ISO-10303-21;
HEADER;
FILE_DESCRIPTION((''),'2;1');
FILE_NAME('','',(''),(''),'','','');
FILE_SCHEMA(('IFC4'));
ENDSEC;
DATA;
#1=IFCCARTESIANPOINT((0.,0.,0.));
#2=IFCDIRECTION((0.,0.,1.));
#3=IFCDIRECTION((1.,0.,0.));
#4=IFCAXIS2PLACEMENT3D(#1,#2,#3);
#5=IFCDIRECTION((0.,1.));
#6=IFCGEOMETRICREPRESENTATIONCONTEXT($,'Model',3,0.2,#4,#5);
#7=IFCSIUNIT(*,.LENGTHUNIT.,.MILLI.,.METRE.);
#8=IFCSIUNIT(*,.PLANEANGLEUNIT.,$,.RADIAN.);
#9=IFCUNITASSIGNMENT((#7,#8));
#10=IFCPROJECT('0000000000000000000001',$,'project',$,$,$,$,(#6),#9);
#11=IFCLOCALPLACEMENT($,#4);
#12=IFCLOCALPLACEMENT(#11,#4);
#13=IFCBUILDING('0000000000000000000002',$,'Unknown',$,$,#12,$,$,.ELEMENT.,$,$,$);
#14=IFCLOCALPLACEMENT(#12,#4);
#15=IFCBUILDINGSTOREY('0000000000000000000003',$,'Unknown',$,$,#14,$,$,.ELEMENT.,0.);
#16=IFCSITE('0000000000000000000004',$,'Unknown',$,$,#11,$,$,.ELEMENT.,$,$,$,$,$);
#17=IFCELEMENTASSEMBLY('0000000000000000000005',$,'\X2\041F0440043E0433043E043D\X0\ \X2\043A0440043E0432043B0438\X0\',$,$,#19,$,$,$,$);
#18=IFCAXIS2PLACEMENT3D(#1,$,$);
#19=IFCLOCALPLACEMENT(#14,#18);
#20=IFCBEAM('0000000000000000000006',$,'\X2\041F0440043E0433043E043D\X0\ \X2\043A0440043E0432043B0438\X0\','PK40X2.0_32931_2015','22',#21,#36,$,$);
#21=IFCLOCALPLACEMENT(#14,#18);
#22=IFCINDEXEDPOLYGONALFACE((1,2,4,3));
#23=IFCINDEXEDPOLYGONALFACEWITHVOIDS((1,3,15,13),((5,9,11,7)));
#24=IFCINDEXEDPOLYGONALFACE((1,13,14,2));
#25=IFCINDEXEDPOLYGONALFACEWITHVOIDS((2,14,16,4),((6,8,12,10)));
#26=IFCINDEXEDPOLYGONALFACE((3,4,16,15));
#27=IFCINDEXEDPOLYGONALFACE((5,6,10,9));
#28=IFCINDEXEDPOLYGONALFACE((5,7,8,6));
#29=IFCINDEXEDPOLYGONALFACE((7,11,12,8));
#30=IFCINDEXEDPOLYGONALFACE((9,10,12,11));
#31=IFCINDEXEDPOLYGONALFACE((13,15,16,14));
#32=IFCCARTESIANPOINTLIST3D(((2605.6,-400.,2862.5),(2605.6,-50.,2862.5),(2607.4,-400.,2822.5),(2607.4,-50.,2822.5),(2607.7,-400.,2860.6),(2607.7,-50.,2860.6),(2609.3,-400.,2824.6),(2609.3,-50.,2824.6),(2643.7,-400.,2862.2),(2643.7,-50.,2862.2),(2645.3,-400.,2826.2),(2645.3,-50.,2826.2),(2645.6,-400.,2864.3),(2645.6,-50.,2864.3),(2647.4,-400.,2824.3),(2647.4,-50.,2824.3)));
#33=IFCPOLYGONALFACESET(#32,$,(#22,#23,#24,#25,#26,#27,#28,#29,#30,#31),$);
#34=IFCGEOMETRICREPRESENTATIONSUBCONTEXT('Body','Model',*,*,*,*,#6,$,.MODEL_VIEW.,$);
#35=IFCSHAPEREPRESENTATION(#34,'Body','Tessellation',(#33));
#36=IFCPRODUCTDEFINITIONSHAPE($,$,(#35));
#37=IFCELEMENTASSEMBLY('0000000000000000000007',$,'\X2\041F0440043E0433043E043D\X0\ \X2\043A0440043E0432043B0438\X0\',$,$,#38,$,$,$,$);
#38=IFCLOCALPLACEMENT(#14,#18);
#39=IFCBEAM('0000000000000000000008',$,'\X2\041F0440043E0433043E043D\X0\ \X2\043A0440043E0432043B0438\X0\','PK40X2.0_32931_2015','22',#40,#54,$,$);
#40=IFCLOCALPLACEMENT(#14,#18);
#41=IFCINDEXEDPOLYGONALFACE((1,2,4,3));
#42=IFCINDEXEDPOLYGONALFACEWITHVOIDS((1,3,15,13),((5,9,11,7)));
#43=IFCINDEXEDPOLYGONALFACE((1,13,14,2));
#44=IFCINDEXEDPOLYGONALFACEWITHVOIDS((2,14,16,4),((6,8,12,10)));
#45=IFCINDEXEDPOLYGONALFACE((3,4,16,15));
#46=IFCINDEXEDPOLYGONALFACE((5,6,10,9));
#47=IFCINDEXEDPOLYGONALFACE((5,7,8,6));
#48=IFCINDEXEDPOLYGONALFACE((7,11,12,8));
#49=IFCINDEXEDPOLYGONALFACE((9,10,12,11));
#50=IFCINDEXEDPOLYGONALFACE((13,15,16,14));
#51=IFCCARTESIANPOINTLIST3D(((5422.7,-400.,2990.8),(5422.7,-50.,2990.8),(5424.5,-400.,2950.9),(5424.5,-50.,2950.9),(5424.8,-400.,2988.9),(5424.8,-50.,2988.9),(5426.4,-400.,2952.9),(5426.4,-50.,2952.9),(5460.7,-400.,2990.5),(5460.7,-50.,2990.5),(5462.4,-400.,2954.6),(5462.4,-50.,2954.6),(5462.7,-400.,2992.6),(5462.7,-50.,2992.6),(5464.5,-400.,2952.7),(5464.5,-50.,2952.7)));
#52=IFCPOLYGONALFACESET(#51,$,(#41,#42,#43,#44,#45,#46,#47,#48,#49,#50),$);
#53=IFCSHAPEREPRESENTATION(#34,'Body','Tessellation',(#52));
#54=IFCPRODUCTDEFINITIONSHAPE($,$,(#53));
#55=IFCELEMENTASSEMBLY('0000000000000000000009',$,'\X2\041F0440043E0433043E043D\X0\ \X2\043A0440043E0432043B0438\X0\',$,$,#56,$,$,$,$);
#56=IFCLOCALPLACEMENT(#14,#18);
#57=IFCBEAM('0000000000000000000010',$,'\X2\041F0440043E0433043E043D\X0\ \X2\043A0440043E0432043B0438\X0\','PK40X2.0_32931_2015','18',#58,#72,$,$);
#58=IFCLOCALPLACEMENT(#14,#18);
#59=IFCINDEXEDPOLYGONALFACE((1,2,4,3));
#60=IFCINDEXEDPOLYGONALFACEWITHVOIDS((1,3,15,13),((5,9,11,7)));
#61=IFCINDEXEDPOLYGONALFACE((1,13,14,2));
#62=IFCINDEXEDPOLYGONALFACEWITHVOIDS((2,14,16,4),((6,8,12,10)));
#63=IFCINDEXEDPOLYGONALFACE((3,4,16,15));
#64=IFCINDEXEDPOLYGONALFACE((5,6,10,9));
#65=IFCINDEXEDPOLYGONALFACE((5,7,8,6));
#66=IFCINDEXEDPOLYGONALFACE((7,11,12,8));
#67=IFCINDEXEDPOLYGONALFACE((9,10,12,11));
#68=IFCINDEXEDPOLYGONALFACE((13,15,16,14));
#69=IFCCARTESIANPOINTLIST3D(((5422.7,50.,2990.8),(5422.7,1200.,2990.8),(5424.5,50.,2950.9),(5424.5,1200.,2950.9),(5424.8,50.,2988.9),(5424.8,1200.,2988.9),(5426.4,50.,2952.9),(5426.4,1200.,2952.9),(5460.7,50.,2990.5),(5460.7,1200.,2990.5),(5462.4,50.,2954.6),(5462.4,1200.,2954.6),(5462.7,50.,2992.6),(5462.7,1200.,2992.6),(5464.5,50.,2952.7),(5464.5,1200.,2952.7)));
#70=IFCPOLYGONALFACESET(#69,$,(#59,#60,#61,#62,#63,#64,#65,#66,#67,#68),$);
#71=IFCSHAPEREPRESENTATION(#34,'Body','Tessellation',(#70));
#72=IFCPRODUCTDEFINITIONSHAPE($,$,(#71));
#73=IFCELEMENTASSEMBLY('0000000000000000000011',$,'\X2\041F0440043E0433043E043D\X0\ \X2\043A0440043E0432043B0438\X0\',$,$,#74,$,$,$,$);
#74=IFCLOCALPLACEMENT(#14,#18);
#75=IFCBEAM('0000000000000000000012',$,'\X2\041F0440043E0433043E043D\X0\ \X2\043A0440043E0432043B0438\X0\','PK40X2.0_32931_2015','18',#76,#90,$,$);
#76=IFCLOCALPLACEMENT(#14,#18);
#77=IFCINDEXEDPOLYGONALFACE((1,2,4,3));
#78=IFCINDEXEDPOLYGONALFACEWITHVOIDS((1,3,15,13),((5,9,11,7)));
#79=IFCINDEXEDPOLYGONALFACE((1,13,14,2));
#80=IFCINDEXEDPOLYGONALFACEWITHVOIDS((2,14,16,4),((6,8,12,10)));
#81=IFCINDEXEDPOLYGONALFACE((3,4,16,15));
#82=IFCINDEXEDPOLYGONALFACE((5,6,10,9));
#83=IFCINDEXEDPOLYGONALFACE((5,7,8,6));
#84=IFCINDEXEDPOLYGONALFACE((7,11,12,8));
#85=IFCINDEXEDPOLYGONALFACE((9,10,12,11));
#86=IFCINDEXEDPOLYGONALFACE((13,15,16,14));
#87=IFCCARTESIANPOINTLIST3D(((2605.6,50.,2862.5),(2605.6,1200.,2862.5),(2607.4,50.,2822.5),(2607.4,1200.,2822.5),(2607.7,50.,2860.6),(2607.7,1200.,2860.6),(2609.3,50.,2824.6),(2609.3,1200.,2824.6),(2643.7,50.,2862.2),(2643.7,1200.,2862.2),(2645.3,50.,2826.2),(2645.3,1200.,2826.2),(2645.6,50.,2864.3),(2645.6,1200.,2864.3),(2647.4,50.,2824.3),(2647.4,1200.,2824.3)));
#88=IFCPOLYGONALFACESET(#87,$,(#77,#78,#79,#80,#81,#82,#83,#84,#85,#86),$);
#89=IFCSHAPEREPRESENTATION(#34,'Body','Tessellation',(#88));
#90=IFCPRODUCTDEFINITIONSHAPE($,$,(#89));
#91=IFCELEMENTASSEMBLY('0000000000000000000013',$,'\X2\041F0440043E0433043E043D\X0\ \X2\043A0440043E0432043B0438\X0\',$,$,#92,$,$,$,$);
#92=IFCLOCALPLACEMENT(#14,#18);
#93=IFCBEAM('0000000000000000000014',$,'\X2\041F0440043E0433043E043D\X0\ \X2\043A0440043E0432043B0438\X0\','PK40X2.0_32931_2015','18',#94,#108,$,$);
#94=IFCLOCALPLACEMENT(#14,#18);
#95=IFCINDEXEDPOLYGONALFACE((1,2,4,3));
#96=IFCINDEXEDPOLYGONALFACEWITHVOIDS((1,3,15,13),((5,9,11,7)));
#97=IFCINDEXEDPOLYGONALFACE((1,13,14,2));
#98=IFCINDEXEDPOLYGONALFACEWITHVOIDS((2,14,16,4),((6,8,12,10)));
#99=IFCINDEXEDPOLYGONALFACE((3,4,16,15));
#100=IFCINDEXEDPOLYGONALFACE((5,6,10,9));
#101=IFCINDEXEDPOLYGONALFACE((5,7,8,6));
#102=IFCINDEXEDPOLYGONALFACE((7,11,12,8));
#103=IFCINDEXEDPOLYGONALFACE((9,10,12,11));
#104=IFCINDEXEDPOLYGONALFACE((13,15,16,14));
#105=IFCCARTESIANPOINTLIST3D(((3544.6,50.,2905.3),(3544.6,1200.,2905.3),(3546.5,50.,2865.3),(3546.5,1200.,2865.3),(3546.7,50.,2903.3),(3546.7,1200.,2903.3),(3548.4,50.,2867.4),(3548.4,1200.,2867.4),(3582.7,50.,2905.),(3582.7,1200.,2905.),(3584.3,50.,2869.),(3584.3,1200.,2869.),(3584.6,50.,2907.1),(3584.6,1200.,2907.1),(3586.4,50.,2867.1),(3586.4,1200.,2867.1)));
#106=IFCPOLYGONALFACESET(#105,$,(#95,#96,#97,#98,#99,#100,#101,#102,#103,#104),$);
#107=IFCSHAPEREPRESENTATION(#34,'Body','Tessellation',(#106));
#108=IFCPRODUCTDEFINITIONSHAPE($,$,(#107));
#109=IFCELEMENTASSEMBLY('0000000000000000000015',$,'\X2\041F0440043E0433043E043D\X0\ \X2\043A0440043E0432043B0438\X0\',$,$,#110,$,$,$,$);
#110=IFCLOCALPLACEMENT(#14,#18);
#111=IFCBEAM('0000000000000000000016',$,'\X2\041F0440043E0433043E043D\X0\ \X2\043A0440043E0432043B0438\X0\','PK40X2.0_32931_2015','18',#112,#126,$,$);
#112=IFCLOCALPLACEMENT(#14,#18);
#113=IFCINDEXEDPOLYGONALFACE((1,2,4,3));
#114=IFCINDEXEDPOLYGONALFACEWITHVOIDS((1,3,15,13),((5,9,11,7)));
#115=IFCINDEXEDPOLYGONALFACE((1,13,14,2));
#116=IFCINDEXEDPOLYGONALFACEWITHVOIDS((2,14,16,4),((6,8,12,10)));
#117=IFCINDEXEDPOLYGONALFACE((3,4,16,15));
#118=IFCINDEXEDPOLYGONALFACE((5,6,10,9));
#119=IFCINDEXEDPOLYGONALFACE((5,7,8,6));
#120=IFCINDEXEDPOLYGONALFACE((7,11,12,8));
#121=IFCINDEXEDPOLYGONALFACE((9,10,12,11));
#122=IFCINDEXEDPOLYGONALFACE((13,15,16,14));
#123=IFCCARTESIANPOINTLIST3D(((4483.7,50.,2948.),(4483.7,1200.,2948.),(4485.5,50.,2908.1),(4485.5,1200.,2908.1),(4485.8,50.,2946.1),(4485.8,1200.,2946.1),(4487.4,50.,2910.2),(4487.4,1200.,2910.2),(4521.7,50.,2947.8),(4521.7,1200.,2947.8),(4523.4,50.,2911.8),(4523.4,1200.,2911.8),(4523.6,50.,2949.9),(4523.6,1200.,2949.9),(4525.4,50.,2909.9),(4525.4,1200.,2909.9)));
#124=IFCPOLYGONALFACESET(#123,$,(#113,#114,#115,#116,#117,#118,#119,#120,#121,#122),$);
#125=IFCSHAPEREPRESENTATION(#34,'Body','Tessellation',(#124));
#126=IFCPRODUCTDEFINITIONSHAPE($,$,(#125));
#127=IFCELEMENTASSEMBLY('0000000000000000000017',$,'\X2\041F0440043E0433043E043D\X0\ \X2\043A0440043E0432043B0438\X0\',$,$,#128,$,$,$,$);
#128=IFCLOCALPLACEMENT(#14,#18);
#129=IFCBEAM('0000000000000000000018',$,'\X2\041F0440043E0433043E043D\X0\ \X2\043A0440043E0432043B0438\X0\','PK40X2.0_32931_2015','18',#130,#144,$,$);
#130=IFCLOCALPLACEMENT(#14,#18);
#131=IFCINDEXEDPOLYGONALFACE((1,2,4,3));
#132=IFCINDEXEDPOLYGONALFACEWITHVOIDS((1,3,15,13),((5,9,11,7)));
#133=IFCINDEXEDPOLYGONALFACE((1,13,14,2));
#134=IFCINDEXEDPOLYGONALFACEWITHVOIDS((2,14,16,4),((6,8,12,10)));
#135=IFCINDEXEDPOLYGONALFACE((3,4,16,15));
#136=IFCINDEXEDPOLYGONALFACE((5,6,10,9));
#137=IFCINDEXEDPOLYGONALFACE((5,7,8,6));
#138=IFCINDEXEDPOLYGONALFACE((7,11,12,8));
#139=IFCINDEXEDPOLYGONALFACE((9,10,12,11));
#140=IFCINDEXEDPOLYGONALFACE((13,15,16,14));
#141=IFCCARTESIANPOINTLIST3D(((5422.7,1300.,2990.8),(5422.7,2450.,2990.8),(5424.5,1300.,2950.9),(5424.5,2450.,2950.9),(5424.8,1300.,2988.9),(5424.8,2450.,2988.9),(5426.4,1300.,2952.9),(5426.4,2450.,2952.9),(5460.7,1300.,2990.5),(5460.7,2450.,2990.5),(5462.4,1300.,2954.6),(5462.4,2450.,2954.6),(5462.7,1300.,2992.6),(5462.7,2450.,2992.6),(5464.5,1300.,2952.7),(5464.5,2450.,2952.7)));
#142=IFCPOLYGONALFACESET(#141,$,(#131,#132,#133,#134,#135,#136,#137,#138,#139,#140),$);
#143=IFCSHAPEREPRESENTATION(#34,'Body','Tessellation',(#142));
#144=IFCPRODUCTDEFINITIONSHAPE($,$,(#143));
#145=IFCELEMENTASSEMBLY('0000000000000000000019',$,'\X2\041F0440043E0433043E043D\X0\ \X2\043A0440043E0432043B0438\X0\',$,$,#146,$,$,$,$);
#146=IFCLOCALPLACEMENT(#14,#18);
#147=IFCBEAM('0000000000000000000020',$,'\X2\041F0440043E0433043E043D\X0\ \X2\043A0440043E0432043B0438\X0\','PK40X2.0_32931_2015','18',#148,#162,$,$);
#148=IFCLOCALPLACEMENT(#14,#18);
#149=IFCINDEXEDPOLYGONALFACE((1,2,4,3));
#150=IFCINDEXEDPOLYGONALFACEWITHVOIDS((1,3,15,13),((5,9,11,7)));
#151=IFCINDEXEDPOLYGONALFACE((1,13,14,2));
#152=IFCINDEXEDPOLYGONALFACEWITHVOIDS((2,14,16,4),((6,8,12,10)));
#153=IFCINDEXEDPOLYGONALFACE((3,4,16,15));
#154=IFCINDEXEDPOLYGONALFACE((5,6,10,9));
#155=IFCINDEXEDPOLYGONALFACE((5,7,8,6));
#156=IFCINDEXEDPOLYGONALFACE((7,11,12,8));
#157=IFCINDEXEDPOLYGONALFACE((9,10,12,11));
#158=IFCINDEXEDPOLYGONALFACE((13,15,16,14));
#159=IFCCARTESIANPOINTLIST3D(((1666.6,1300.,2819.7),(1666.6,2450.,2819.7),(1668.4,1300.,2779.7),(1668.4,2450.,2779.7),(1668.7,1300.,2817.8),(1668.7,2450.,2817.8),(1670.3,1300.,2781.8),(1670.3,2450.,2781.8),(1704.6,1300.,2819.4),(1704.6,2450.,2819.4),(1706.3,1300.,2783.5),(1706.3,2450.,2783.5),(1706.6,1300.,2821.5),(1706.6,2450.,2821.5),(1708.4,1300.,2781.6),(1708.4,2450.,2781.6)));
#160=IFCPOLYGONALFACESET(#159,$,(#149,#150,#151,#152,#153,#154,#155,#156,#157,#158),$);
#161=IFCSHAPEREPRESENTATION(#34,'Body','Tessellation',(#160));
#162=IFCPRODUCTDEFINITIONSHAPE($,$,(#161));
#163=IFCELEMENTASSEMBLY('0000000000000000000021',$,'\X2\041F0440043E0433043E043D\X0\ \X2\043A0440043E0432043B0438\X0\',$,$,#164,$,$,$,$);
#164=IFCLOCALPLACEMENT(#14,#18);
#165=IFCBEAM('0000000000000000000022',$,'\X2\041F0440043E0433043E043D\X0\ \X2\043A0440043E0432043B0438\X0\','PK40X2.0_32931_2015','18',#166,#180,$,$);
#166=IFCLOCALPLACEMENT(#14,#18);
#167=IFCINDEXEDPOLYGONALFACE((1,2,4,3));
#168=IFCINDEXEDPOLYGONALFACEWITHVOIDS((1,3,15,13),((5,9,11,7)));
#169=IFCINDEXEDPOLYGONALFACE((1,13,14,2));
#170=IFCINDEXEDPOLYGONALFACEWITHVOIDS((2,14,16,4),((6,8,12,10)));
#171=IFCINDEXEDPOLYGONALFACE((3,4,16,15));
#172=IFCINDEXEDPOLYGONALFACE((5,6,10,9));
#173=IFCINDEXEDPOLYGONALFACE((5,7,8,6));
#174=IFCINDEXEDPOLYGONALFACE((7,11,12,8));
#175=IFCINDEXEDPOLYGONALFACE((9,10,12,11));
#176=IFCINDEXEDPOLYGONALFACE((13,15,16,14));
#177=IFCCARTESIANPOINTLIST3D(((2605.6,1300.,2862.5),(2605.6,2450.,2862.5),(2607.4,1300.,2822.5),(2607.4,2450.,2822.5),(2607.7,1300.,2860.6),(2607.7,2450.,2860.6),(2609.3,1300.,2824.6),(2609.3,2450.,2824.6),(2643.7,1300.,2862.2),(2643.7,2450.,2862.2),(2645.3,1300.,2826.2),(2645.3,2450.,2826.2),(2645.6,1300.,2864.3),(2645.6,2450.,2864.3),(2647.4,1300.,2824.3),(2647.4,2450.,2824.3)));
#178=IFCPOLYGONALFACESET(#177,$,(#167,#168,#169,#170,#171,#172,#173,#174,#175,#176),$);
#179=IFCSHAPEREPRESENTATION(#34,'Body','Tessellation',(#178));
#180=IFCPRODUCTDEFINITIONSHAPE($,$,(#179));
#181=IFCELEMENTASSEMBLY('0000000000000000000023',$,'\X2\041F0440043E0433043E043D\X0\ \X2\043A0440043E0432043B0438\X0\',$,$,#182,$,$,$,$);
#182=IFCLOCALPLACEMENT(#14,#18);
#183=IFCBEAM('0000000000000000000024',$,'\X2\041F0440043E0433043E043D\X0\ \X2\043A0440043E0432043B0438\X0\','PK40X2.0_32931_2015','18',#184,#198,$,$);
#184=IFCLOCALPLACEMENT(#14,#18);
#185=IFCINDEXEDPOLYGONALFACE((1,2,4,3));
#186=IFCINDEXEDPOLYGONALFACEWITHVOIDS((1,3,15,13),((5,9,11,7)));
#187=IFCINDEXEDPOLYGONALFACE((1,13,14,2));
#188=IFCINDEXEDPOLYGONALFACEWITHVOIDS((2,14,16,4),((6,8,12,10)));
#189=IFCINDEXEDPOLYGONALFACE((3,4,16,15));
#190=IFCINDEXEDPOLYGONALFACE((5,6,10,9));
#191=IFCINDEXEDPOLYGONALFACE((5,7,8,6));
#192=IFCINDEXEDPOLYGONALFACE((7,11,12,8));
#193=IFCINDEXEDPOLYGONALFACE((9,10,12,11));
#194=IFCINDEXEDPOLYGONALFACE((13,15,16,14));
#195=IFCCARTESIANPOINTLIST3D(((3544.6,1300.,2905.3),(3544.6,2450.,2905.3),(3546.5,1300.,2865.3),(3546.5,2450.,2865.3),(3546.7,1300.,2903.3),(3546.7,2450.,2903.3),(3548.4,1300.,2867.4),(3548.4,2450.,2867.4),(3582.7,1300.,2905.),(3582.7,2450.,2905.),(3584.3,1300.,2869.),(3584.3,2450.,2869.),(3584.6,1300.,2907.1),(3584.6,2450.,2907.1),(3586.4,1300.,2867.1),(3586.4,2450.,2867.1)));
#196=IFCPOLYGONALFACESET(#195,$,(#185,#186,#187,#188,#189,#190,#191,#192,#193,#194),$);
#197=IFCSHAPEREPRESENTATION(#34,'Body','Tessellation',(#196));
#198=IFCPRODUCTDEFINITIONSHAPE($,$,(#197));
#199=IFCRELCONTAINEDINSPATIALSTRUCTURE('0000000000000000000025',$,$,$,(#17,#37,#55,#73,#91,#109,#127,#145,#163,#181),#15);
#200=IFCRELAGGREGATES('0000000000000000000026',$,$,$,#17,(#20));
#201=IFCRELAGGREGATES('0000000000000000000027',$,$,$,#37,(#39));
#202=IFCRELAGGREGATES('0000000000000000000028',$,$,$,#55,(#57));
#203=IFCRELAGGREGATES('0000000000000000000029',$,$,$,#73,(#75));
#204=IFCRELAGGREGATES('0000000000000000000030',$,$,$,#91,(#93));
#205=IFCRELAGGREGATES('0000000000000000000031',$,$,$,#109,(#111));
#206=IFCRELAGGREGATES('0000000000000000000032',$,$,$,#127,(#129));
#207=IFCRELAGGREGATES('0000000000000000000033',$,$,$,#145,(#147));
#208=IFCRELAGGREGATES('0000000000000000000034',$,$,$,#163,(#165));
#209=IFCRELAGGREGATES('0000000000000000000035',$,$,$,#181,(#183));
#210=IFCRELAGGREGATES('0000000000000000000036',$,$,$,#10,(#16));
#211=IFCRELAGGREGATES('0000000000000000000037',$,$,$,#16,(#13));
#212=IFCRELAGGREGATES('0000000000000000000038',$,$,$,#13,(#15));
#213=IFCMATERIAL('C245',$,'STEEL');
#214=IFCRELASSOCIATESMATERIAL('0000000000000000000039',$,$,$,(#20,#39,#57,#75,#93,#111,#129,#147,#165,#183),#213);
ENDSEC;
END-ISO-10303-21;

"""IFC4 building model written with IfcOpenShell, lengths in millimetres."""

from ifc_helpers import new_model, si_unit, direction, frame, origin_with_axes, place, context, subcontext, project, spatial, line, indexed_curve, outline, extrude, material, element, aggregate, save


model = new_model("IFC4")

# Units and contexts
model_context = context("Model", 3, precision=0.2, world=origin_with_axes(), true_north=direction((0.0, 1.0)))
body_context = subcontext(model_context, "Body", "Model", "MODEL_VIEW")
ifc_project = project(units=[si_unit("LENGTHUNIT", "METRE", prefix="MILLI"), si_unit("PLANEANGLEUNIT", "RADIAN")], contexts=[model_context])

# Site, building, storey
site_placement = place(None, origin_with_axes())
site = spatial("IfcSite", under=ifc_project, at=site_placement, Name="Unknown", CompositionType="ELEMENT")
building_placement = place(site_placement, origin_with_axes())
building = spatial("IfcBuilding", under=site, at=building_placement, Name="Unknown", CompositionType="ELEMENT")
storey_placement = place(building_placement, origin_with_axes())
storey = spatial("IfcBuildingStorey", under=building, at=storey_placement, Name="Unknown", CompositionType="ELEMENT", Elevation=0.0)

# Shared definitions
ifc_material = material(Name="C245", Category="STEEL")

# Element assemblies, beams
assembly_1_placement = place(storey_placement, frame((2626.5, -50.0, 2843.4), z_axis=(-0.998964, 0.0, -0.045508), x_axis=(0.0, -1.0, 0.0)))
assembly_1 = element("IfcElementAssembly", 1, at=assembly_1_placement, inside=storey, Name="Прогон кровли")
beam_1_placement = place(assembly_1_placement, origin_with_axes())
beam_1 = element("IfcBeam", 2, at=beam_1_placement, material=ifc_material, Name="Прогон кровли", Description="PK40X2.0_32931_2015", ObjectType="22", context=body_context, shape_type="SolidModel", body=[
    extrude(outline(indexed_curve([(-20.0, -20.0), (20.0, -20.0), (20.0, 20.0), (-20.0, 20.0)], segments=[line(1, 2, 3, 4, 1)]), holes=[indexed_curve([(-18.0, -18.0), (-18.0, 18.0), (18.0, 18.0), (18.0, -18.0)], segments=[line(1, 2, 3, 4, 1)])]), frame((0.0, 0.0, 0.0), z_axis=(-1.0, 0.0, 0.0), x_axis=(0.0, 0.0, 1.0)), (0.0, 0.0, -1.0), 350.0),
])
aggregate(assembly_1, [beam_1])
assembly_2_placement = place(storey_placement, frame((5443.6, -50.0, 2971.7), z_axis=(-0.998964, 0.0, -0.045508), x_axis=(0.0, -1.0, 0.0)))
assembly_2 = element("IfcElementAssembly", 3, at=assembly_2_placement, inside=storey, Name="Прогон кровли")
beam_2_placement = place(assembly_2_placement, origin_with_axes())
beam_2 = element("IfcBeam", 4, at=beam_2_placement, material=ifc_material, Name="Прогон кровли", Description="PK40X2.0_32931_2015", ObjectType="22", context=body_context, shape_type="SolidModel", body=[
    extrude(outline(indexed_curve([(-20.0, -20.0), (20.0, -20.0), (20.0, 20.0), (-20.0, 20.0)], segments=[line(1, 2, 3, 4, 1)]), holes=[indexed_curve([(-18.0, -18.0), (-18.0, 18.0), (18.0, 18.0), (18.0, -18.0)], segments=[line(1, 2, 3, 4, 1)])]), frame((0.0, 0.0, 0.0), z_axis=(-1.0, 0.0, 0.0), x_axis=(0.0, 0.0, 1.0)), (0.0, 0.0, -1.0), 350.0),
])
aggregate(assembly_2, [beam_2])
assembly_3_placement = place(storey_placement, frame((5443.6, 1200.0, 2971.7), z_axis=(-0.998964, 0.0, -0.045508), x_axis=(0.0, -1.0, 0.0)))
assembly_3 = element("IfcElementAssembly", 5, at=assembly_3_placement, inside=storey, Name="Прогон кровли")
beam_3_placement = place(assembly_3_placement, origin_with_axes())
beam_3 = element("IfcBeam", 6, at=beam_3_placement, material=ifc_material, Name="Прогон кровли", Description="PK40X2.0_32931_2015", ObjectType="18", context=body_context, shape_type="SolidModel", body=[
    extrude(outline(indexed_curve([(-20.0, -20.0), (20.0, -20.0), (20.0, 20.0), (-20.0, 20.0)], segments=[line(1, 2, 3, 4, 1)]), holes=[indexed_curve([(-18.0, -18.0), (-18.0, 18.0), (18.0, 18.0), (18.0, -18.0)], segments=[line(1, 2, 3, 4, 1)])]), frame((0.0, 0.0, 0.0), z_axis=(-1.0, 0.0, 0.0), x_axis=(0.0, 0.0, 1.0)), (0.0, 0.0, -1.0), 1150.0),
])
aggregate(assembly_3, [beam_3])
assembly_4_placement = place(storey_placement, frame((2626.5, 1200.0, 2843.4), z_axis=(-0.998964, 0.0, -0.045508), x_axis=(0.0, -1.0, 0.0)))
assembly_4 = element("IfcElementAssembly", 7, at=assembly_4_placement, inside=storey, Name="Прогон кровли")
beam_4_placement = place(assembly_4_placement, origin_with_axes())
beam_4 = element("IfcBeam", 8, at=beam_4_placement, material=ifc_material, Name="Прогон кровли", Description="PK40X2.0_32931_2015", ObjectType="18", context=body_context, shape_type="SolidModel", body=[
    extrude(outline(indexed_curve([(-20.0, -20.0), (20.0, -20.0), (20.0, 20.0), (-20.0, 20.0)], segments=[line(1, 2, 3, 4, 1)]), holes=[indexed_curve([(-18.0, -18.0), (-18.0, 18.0), (18.0, 18.0), (18.0, -18.0)], segments=[line(1, 2, 3, 4, 1)])]), frame((0.0, 0.0, 0.0), z_axis=(-1.0, 0.0, 0.0), x_axis=(0.0, 0.0, 1.0)), (0.0, 0.0, -1.0), 1150.0),
])
aggregate(assembly_4, [beam_4])
assembly_5_placement = place(storey_placement, frame((3565.5, 1200.0, 2886.2), z_axis=(-0.998964, 0.0, -0.045508), x_axis=(0.0, -1.0, 0.0)))
assembly_5 = element("IfcElementAssembly", 9, at=assembly_5_placement, inside=storey, Name="Прогон кровли")
beam_5_placement = place(assembly_5_placement, origin_with_axes())
beam_5 = element("IfcBeam", 10, at=beam_5_placement, material=ifc_material, Name="Прогон кровли", Description="PK40X2.0_32931_2015", ObjectType="18", context=body_context, shape_type="SolidModel", body=[
    extrude(outline(indexed_curve([(-20.0, -20.0), (20.0, -20.0), (20.0, 20.0), (-20.0, 20.0)], segments=[line(1, 2, 3, 4, 1)]), holes=[indexed_curve([(-18.0, -18.0), (-18.0, 18.0), (18.0, 18.0), (18.0, -18.0)], segments=[line(1, 2, 3, 4, 1)])]), frame((0.0, 0.0, 0.0), z_axis=(-1.0, 0.0, 0.0), x_axis=(0.0, 0.0, 1.0)), (0.0, 0.0, -1.0), 1150.0),
])
aggregate(assembly_5, [beam_5])
assembly_6_placement = place(storey_placement, frame((4504.6, 1200.0, 2929.0), z_axis=(-0.998964, 0.0, -0.045508), x_axis=(0.0, -1.0, 0.0)))
assembly_6 = element("IfcElementAssembly", 11, at=assembly_6_placement, inside=storey, Name="Прогон кровли")
beam_6_placement = place(assembly_6_placement, origin_with_axes())
beam_6 = element("IfcBeam", 12, at=beam_6_placement, material=ifc_material, Name="Прогон кровли", Description="PK40X2.0_32931_2015", ObjectType="18", context=body_context, shape_type="SolidModel", body=[
    extrude(outline(indexed_curve([(-20.0, -20.0), (20.0, -20.0), (20.0, 20.0), (-20.0, 20.0)], segments=[line(1, 2, 3, 4, 1)]), holes=[indexed_curve([(-18.0, -18.0), (-18.0, 18.0), (18.0, 18.0), (18.0, -18.0)], segments=[line(1, 2, 3, 4, 1)])]), frame((0.0, 0.0, 0.0), z_axis=(-1.0, 0.0, 0.0), x_axis=(0.0, 0.0, 1.0)), (0.0, 0.0, -1.0), 1150.0),
])
aggregate(assembly_6, [beam_6])
assembly_7_placement = place(storey_placement, frame((5443.6, 2450.0, 2971.7), z_axis=(-0.998964, 0.0, -0.045508), x_axis=(0.0, -1.0, 0.0)))
assembly_7 = element("IfcElementAssembly", 13, at=assembly_7_placement, inside=storey, Name="Прогон кровли")
beam_7_placement = place(assembly_7_placement, origin_with_axes())
beam_7 = element("IfcBeam", 14, at=beam_7_placement, material=ifc_material, Name="Прогон кровли", Description="PK40X2.0_32931_2015", ObjectType="18", context=body_context, shape_type="SolidModel", body=[
    extrude(outline(indexed_curve([(-20.0, -20.0), (20.0, -20.0), (20.0, 20.0), (-20.0, 20.0)], segments=[line(1, 2, 3, 4, 1)]), holes=[indexed_curve([(-18.0, -18.0), (-18.0, 18.0), (18.0, 18.0), (18.0, -18.0)], segments=[line(1, 2, 3, 4, 1)])]), frame((0.0, 0.0, 0.0), z_axis=(-1.0, 0.0, 0.0), x_axis=(0.0, 0.0, 1.0)), (0.0, 0.0, -1.0), 1150.0),
])
aggregate(assembly_7, [beam_7])
assembly_8_placement = place(storey_placement, frame((1687.5, 2450.0, 2800.6), z_axis=(-0.998964, 0.0, -0.045508), x_axis=(0.0, -1.0, 0.0)))
assembly_8 = element("IfcElementAssembly", 15, at=assembly_8_placement, inside=storey, Name="Прогон кровли")
beam_8_placement = place(assembly_8_placement, origin_with_axes())
beam_8 = element("IfcBeam", 16, at=beam_8_placement, material=ifc_material, Name="Прогон кровли", Description="PK40X2.0_32931_2015", ObjectType="18", context=body_context, shape_type="SolidModel", body=[
    extrude(outline(indexed_curve([(-20.0, -20.0), (20.0, -20.0), (20.0, 20.0), (-20.0, 20.0)], segments=[line(1, 2, 3, 4, 1)]), holes=[indexed_curve([(-18.0, -18.0), (-18.0, 18.0), (18.0, 18.0), (18.0, -18.0)], segments=[line(1, 2, 3, 4, 1)])]), frame((0.0, 0.0, 0.0), z_axis=(-1.0, 0.0, 0.0), x_axis=(0.0, 0.0, 1.0)), (0.0, 0.0, -1.0), 1150.0),
])
aggregate(assembly_8, [beam_8])
assembly_9_placement = place(storey_placement, frame((2626.5, 2450.0, 2843.4), z_axis=(-0.998964, 0.0, -0.045508), x_axis=(0.0, -1.0, 0.0)))
assembly_9 = element("IfcElementAssembly", 17, at=assembly_9_placement, inside=storey, Name="Прогон кровли")
beam_9_placement = place(assembly_9_placement, origin_with_axes())
beam_9 = element("IfcBeam", 18, at=beam_9_placement, material=ifc_material, Name="Прогон кровли", Description="PK40X2.0_32931_2015", ObjectType="18", context=body_context, shape_type="SolidModel", body=[
    extrude(outline(indexed_curve([(-20.0, -20.0), (20.0, -20.0), (20.0, 20.0), (-20.0, 20.0)], segments=[line(1, 2, 3, 4, 1)]), holes=[indexed_curve([(-18.0, -18.0), (-18.0, 18.0), (18.0, 18.0), (18.0, -18.0)], segments=[line(1, 2, 3, 4, 1)])]), frame((0.0, 0.0, 0.0), z_axis=(-1.0, 0.0, 0.0), x_axis=(0.0, 0.0, 1.0)), (0.0, 0.0, -1.0), 1150.0),
])
aggregate(assembly_9, [beam_9])
assembly_10_placement = place(storey_placement, frame((3565.5, 2450.0, 2886.2), z_axis=(-0.998964, 0.0, -0.045508), x_axis=(0.0, -1.0, 0.0)))
assembly_10 = element("IfcElementAssembly", 19, at=assembly_10_placement, inside=storey, Name="Прогон кровли")
beam_10_placement = place(assembly_10_placement, origin_with_axes())
beam_10 = element("IfcBeam", 20, at=beam_10_placement, material=ifc_material, Name="Прогон кровли", Description="PK40X2.0_32931_2015", ObjectType="18", context=body_context, shape_type="SolidModel", body=[
    extrude(outline(indexed_curve([(-20.0, -20.0), (20.0, -20.0), (20.0, 20.0), (-20.0, 20.0)], segments=[line(1, 2, 3, 4, 1)]), holes=[indexed_curve([(-18.0, -18.0), (-18.0, 18.0), (18.0, 18.0), (18.0, -18.0)], segments=[line(1, 2, 3, 4, 1)])]), frame((0.0, 0.0, 0.0), z_axis=(-1.0, 0.0, 0.0), x_axis=(0.0, 0.0, 1.0)), (0.0, 0.0, -1.0), 1150.0),
])
aggregate(assembly_10, [beam_10])

save(model, "model.ifc")
